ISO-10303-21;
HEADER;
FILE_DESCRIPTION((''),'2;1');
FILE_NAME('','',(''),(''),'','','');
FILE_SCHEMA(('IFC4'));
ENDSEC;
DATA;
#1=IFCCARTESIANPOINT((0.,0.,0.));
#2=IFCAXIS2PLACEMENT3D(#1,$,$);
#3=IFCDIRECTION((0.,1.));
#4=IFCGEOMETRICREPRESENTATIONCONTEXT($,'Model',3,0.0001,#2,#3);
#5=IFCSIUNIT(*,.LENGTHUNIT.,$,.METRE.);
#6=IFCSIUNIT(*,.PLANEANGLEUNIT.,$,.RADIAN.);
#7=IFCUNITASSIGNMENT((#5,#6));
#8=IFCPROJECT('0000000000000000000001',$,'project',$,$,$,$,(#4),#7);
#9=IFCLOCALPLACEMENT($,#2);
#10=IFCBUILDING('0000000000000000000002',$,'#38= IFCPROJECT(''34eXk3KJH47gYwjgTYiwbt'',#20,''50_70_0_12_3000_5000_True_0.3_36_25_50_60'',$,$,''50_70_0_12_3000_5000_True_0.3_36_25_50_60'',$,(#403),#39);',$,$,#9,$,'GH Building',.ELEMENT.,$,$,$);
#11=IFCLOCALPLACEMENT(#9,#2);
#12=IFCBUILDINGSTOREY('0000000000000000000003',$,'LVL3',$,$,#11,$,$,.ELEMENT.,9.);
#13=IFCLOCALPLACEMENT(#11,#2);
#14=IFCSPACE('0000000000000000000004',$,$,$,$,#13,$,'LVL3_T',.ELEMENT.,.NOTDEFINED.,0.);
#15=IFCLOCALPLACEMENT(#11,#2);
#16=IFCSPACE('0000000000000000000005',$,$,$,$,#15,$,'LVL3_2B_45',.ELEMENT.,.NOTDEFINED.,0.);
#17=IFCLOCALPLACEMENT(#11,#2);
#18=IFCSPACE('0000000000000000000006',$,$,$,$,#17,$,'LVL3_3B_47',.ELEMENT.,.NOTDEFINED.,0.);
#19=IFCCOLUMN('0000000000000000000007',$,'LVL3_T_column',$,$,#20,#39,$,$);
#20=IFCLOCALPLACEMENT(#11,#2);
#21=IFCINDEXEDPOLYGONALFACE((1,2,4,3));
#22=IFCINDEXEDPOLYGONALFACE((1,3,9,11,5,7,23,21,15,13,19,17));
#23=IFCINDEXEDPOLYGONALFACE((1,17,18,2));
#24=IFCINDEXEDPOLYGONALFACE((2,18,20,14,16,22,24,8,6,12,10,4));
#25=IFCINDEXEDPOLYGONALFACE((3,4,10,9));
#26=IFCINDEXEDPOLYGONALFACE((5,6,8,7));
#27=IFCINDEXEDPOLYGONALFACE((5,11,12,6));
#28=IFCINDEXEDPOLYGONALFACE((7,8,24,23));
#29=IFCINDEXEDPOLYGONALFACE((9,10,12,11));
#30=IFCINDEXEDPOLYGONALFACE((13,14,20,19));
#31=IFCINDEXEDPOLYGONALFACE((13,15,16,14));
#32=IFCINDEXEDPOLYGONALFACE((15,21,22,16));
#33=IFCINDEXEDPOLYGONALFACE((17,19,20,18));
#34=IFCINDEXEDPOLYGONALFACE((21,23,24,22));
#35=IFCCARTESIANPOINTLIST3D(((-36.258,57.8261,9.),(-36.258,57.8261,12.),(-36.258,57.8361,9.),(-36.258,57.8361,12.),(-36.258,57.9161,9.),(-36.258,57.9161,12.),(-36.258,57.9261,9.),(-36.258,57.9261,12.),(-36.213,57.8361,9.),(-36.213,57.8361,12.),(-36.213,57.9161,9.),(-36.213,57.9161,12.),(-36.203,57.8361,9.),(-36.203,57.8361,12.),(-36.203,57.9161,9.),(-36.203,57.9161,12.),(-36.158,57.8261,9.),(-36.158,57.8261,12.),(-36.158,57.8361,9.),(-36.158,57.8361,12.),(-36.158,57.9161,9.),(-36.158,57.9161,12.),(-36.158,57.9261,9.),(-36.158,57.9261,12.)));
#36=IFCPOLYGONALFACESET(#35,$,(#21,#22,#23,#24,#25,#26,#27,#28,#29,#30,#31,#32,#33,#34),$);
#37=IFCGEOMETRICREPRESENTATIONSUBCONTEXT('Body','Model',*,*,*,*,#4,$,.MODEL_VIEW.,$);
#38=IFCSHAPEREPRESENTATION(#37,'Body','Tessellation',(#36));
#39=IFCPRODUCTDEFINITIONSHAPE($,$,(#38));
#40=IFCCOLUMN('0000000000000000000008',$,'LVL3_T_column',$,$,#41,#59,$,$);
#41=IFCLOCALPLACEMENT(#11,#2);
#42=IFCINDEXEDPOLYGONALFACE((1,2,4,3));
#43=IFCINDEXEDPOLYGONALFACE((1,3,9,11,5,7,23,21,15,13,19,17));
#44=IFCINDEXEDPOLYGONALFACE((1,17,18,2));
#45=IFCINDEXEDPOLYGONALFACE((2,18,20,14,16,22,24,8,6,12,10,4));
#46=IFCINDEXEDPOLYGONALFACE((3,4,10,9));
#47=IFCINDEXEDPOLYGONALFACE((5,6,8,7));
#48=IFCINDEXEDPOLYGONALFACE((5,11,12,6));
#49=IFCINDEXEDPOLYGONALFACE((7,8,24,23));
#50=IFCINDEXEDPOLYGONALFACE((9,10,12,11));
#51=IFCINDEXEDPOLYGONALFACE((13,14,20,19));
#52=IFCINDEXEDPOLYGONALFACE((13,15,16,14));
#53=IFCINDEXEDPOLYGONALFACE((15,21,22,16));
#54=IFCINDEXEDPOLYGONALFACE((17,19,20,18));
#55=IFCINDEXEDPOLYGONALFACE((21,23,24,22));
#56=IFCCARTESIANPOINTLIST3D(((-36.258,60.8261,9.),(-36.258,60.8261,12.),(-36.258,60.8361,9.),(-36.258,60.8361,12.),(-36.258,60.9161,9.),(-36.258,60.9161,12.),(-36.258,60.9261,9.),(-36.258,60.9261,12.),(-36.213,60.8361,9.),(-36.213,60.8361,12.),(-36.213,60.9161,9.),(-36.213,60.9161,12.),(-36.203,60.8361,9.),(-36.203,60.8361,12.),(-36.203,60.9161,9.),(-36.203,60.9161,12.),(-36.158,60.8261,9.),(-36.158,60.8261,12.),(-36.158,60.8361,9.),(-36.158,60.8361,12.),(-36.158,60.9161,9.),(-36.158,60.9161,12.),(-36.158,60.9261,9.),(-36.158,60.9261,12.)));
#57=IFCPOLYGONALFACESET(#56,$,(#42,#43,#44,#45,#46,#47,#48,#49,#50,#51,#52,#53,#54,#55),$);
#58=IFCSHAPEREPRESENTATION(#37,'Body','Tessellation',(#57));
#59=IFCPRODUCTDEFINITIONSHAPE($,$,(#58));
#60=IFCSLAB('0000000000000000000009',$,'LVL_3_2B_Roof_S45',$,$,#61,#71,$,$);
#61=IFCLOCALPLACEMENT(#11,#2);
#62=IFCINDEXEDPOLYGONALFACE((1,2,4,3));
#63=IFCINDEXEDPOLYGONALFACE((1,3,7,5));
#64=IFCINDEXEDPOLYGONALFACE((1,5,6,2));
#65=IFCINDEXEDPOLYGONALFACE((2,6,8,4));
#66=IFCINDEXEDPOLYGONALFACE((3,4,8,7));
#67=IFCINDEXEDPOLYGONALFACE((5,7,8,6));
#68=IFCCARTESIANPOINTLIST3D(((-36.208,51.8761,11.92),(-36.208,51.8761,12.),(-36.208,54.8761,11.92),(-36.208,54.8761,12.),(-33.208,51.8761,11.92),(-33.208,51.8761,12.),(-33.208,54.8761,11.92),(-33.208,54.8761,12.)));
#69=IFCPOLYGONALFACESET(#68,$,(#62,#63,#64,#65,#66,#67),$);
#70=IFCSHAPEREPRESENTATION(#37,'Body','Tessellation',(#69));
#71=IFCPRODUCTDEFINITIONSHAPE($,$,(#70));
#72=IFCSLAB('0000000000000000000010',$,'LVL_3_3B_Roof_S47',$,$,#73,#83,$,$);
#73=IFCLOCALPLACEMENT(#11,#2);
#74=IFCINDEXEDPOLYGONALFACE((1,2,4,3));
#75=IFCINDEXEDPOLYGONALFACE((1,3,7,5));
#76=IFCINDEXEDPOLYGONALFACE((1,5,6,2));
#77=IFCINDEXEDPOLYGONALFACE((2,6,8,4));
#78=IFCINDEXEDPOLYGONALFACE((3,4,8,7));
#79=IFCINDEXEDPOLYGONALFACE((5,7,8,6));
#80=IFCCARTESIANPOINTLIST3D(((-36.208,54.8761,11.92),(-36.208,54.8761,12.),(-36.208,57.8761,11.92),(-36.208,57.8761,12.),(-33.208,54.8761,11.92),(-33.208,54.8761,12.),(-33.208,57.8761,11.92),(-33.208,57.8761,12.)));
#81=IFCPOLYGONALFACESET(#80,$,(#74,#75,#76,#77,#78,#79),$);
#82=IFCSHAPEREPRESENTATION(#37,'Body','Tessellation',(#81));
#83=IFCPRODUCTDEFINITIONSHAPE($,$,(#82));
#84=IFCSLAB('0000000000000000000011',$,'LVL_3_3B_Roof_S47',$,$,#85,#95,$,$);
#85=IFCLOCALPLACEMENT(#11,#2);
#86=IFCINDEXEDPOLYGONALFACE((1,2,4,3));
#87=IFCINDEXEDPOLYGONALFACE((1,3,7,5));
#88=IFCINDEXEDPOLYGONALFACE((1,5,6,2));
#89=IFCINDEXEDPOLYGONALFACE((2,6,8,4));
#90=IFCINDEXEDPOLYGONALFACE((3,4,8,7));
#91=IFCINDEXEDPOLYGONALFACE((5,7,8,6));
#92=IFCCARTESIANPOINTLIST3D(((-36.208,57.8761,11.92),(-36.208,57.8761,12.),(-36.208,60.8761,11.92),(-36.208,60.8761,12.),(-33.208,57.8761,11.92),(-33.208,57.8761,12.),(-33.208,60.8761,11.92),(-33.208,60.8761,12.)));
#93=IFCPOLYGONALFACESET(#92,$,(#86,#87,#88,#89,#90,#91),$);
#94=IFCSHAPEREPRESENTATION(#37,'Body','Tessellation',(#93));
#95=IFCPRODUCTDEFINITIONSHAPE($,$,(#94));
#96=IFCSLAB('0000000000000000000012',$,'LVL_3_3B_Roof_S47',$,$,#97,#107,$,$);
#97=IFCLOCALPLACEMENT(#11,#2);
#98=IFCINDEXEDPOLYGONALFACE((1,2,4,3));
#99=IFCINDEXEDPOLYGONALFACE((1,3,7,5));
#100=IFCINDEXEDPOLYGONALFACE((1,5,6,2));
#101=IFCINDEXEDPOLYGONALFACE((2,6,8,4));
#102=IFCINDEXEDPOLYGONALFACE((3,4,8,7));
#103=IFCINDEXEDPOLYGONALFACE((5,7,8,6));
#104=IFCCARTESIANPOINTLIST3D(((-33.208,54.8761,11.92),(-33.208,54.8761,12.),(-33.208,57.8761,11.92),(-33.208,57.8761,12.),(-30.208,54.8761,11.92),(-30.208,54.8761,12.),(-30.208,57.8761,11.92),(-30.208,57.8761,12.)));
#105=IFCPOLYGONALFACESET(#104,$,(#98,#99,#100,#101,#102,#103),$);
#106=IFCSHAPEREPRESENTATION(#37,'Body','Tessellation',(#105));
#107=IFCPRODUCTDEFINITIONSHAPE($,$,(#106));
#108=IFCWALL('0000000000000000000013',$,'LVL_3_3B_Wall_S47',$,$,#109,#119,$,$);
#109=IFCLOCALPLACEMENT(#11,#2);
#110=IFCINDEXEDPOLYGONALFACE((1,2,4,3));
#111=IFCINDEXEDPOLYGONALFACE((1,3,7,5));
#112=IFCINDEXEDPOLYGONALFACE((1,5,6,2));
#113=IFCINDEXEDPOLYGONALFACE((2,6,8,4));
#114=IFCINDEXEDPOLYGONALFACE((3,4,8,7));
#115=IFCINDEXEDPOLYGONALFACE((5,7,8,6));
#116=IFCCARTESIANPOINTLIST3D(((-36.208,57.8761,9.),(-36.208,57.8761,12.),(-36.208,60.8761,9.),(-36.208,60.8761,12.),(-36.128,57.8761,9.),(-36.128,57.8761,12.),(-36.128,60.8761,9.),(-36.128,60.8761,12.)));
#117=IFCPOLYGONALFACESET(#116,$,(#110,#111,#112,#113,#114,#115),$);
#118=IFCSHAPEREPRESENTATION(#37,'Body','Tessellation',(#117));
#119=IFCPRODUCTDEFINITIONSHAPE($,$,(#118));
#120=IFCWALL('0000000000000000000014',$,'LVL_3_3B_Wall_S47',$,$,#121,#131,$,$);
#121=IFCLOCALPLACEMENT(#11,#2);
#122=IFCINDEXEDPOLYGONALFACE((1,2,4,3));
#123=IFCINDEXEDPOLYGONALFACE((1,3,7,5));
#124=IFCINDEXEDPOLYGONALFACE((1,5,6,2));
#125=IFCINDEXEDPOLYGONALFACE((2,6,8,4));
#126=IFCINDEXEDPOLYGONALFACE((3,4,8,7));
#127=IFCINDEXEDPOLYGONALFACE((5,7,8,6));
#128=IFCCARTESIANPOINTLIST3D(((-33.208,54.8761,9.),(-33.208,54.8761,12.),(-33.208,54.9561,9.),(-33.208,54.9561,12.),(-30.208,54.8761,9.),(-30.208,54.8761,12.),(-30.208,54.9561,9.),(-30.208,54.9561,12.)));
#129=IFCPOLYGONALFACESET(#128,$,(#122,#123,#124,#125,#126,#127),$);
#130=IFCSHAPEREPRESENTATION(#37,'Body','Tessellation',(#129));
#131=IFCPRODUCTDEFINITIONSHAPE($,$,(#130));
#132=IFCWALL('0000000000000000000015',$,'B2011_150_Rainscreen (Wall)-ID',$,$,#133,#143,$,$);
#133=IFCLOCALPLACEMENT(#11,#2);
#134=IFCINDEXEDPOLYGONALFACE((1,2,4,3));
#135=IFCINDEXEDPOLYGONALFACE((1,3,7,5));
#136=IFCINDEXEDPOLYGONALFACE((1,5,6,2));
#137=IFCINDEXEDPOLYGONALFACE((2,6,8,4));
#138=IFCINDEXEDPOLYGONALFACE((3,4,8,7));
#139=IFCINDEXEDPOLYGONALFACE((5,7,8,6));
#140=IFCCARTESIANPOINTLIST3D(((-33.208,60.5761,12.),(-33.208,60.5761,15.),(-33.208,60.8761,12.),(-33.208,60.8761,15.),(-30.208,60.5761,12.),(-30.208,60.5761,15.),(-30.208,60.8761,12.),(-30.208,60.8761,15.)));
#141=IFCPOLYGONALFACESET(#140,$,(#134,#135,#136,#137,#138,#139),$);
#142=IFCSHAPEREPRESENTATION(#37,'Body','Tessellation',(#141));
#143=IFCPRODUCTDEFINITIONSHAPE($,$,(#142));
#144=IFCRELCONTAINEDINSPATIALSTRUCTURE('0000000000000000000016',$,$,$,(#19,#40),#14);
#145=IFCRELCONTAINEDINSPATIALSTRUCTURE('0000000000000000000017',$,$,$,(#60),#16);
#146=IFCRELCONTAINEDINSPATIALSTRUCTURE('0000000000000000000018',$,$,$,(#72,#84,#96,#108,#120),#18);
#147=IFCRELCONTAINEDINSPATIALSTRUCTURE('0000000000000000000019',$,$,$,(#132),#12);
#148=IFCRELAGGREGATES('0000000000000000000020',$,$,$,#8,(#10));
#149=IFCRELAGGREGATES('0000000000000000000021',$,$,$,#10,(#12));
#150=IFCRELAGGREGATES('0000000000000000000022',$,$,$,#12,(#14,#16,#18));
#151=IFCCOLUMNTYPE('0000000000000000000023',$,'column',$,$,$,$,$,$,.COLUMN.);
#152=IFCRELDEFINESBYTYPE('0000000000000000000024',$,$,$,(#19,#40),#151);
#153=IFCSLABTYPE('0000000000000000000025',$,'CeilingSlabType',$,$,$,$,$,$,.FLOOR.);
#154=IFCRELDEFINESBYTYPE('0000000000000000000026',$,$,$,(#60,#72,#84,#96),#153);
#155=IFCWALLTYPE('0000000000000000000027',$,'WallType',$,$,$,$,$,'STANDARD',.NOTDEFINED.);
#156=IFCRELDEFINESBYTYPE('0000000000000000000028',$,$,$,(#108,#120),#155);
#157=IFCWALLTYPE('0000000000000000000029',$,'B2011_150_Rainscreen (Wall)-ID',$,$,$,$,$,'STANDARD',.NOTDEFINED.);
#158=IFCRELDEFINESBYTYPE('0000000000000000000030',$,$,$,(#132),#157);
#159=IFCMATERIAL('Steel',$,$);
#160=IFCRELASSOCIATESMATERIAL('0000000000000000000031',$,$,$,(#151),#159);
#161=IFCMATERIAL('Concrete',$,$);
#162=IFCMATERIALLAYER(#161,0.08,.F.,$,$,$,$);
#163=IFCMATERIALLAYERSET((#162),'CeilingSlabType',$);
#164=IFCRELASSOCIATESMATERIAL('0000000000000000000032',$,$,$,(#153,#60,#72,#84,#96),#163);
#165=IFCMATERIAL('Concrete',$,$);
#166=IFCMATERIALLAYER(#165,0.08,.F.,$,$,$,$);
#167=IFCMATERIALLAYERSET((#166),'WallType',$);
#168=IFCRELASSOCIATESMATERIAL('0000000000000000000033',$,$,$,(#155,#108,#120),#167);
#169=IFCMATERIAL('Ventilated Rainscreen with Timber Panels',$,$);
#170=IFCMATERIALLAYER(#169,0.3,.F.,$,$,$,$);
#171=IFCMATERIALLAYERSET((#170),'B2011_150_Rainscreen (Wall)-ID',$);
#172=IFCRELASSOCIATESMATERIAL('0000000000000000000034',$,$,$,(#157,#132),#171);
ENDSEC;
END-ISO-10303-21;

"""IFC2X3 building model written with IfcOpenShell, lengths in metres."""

from ifc_helpers import new_model, si_unit, direction, frame, frame_2d, origin, origin_2d, place, context, subcontext, project, spatial, rectangle, i_section, extrude, material, layer, layer_set, layer_usage, type_object, element, save


model = new_model("IFC2X3")

# Units and contexts
model_context = context("Model", 3, precision=0.0001, world=origin(), true_north=direction((0.0, 1.0)))
body_context = subcontext(model_context, "Body", "Model", "MODEL_VIEW")
ifc_project = project(units=[si_unit("LENGTHUNIT", "METRE"), si_unit("PLANEANGLEUNIT", "RADIAN")], contexts=[model_context])

# Building, storey, space
building_placement = place(None, origin())
building = spatial("IfcBuilding", under=ifc_project, at=building_placement, Name="#38= IFCPROJECT('34eXk3KJH47gYwjgTYiwbt',#20,'50_70_0_12_3000_5000_True_0.3_36_25_50_60',$,$,'50_70_0_12_3000_5000_True_0.3_36_25_50_60',$,(#403),#39);", LongName="GH Building", CompositionType="ELEMENT")
storey_placement = place(building_placement, origin())
storey = spatial("IfcBuildingStorey", under=building, at=storey_placement, Name="LVL3", CompositionType="ELEMENT", Elevation=9.0)
space_1_placement = place(storey_placement, origin())
space_1 = spatial("IfcSpace", under=storey, at=space_1_placement, LongName="LVL3_T", CompositionType="ELEMENT", InteriorOrExteriorSpace="NOTDEFINED", ElevationWithFlooring=0.0)

# Columns
ifc_material_1 = material(Name="Steel")
column_type = type_object("IfcColumnType", Name="column", PredefinedType="COLUMN", material=ifc_material_1)
for number, where, name in (
    (1, (-36.208, 57.8761, 9.0), "LVL3_T_column"),
    (2, (-36.208, 60.8761, 9.0), "LVL3_T_column"),
):
    element("IfcColumn", number, at=place(space_1_placement, frame(where)), inside=space_1, type_object=column_type, Name=name, context=body_context, shape_type="SweptSolid", body=[
        extrude(i_section(OverallWidth=0.1, OverallDepth=0.1, WebThickness=0.01, FlangeThickness=0.01, at=origin_2d()), origin(), (0.0, 0.0, 1.0), 3.0),
    ])

# Shared definitions
space_2_placement = place(storey_placement, origin())
space_2 = spatial("IfcSpace", under=storey, at=space_2_placement, LongName="LVL3_2B_45", CompositionType="ELEMENT", InteriorOrExteriorSpace="NOTDEFINED", ElevationWithFlooring=0.0)

# Slab
ifc_material_2 = material(Name="Concrete")
ifc_layer_1 = layer(ifc_material_2, 0.08, ventilated=False)
ifc_layer_set_1 = layer_set([ifc_layer_1], Name="CeilingSlabType")
ifc_layer_usage_1 = layer_usage(ifc_layer_set_1, "AXIS3", "NEGATIVE", -0.08)
slab_type = type_object("IfcSlabType", Name="CeilingSlabType", PredefinedType="FLOOR", material=ifc_layer_set_1)
slab_1_placement = place(space_2_placement, frame((-33.208, 51.8761, 11.92), z_axis=(0.0, 0.0, 1.0), x_axis=(0.0, 1.0, 0.0)))
element("IfcSlab", 3, at=slab_1_placement, inside=space_2, type_object=slab_type, material=ifc_layer_usage_1, Name="LVL_3_2B_Roof_S45", context=body_context, shape_type="SweptSolid", body=[
    extrude(rectangle(XDim=3.0, YDim=3.0, at=frame_2d((1.5, 1.5))), origin(), (0.0, 0.0, 1.0), 0.08),
])

# Shared definitions
space_3_placement = place(storey_placement, origin())
space_3 = spatial("IfcSpace", under=storey, at=space_3_placement, LongName="LVL3_3B_47", CompositionType="ELEMENT", InteriorOrExteriorSpace="NOTDEFINED", ElevationWithFlooring=0.0)

# Slabs
ifc_layer_usage_2 = layer_usage(ifc_layer_set_1, "AXIS3", "NEGATIVE", -0.08)
slab_2_placement = place(space_3_placement, frame((-33.208, 54.8761, 11.92), z_axis=(0.0, 0.0, 1.0), x_axis=(0.0, 1.0, 0.0)))
element("IfcSlab", 4, at=slab_2_placement, inside=space_3, type_object=slab_type, material=ifc_layer_usage_2, Name="LVL_3_3B_Roof_S47", context=body_context, shape_type="SweptSolid", body=[
    extrude(rectangle(XDim=3.0, YDim=3.0, at=frame_2d((1.5, 1.5))), origin(), (0.0, 0.0, 1.0), 0.08),
])
ifc_layer_usage_3 = layer_usage(ifc_layer_set_1, "AXIS3", "NEGATIVE", -0.08)
slab_3_placement = place(space_3_placement, frame((-33.208, 57.8761, 11.92), z_axis=(0.0, 0.0, 1.0), x_axis=(0.0, 1.0, 0.0)))
element("IfcSlab", 5, at=slab_3_placement, inside=space_3, type_object=slab_type, material=ifc_layer_usage_3, Name="LVL_3_3B_Roof_S47", context=body_context, shape_type="SweptSolid", body=[
    extrude(rectangle(XDim=3.0, YDim=3.0, at=frame_2d((1.5, 1.5))), origin(), (0.0, 0.0, 1.0), 0.08),
])
ifc_layer_usage_4 = layer_usage(ifc_layer_set_1, "AXIS3", "NEGATIVE", -0.08)
slab_4_placement = place(space_3_placement, frame((-30.208, 54.8761, 11.92), z_axis=(0.0, 0.0, 1.0), x_axis=(0.0, 1.0, 0.0)))
element("IfcSlab", 6, at=slab_4_placement, inside=space_3, type_object=slab_type, material=ifc_layer_usage_4, Name="LVL_3_3B_Roof_S47", context=body_context, shape_type="SweptSolid", body=[
    extrude(rectangle(XDim=3.0, YDim=3.0, at=frame_2d((1.5, 1.5))), origin(), (0.0, 0.0, 1.0), 0.08),
])

# Shared definitions
ifc_material_3 = material(Name="Concrete")
ifc_layer_2 = layer(ifc_material_3, 0.08, ventilated=False)
ifc_layer_set_2 = layer_set([ifc_layer_2], Name="WallType")
wall_type_1 = type_object("IfcWallType", Name="WallType", ElementType="STANDARD", PredefinedType="NOTDEFINED", material=ifc_layer_set_2)

# Walls
ifc_layer_usage_5 = layer_usage(ifc_layer_set_2, "AXIS2", "NEGATIVE", 0.0)
wall_1_placement = place(space_3_placement, frame((-36.208, 57.8761, 9.0), z_axis=(0.0, 0.0, 1.0), x_axis=(0.0, 1.0, 0.0)))
element("IfcWall", 7, at=wall_1_placement, inside=space_3, type_object=wall_type_1, material=ifc_layer_usage_5, Name="LVL_3_3B_Wall_S47", context=body_context, shape_type="SweptSolid", body=[
    extrude(rectangle(XDim=3.0, YDim=0.08, at=frame_2d((1.5, -0.04))), origin(), (0.0, 0.0, 1.0), 3.0),
])
ifc_layer_usage_6 = layer_usage(ifc_layer_set_2, "AXIS2", "NEGATIVE", 0.0)
wall_2_placement = place(space_3_placement, frame((-30.208, 54.8761, 9.0), z_axis=(0.0, 0.0, 1.0), x_axis=(-1.0, 0.0, 0.0)))
element("IfcWall", 8, at=wall_2_placement, inside=space_3, type_object=wall_type_1, material=ifc_layer_usage_6, Name="LVL_3_3B_Wall_S47", context=body_context, shape_type="SweptSolid", body=[
    extrude(rectangle(XDim=3.0, YDim=0.08, at=frame_2d((1.5, -0.04))), origin(), (0.0, 0.0, 1.0), 3.0),
])
ifc_material_4 = material(Name="Ventilated Rainscreen with Timber Panels")
ifc_layer_3 = layer(ifc_material_4, 0.3, ventilated=False)
ifc_layer_set_3 = layer_set([ifc_layer_3], Name="B2011_150_Rainscreen (Wall)-ID")
ifc_layer_usage_7 = layer_usage(ifc_layer_set_3, "AXIS2", "POSITIVE", 0.0)
wall_type_2 = type_object("IfcWallType", Name="B2011_150_Rainscreen (Wall)-ID", ElementType="STANDARD", PredefinedType="NOTDEFINED", material=ifc_layer_set_3)
wall_3_placement = place(storey_placement, frame((-30.208, 60.8761, 12.0), z_axis=(0.0, 0.0, 1.0), x_axis=(-1.0, 0.0, 0.0)))
element("IfcWall", 9, at=wall_3_placement, inside=storey, type_object=wall_type_2, material=ifc_layer_usage_7, Name="B2011_150_Rainscreen (Wall)-ID", context=body_context, shape_type="SweptSolid", body=[
    extrude(rectangle(XDim=3.0, YDim=0.3, at=frame_2d((1.5, 0.15))), origin(), (0.0, 0.0, 1.0), 3.0),
])

save(model, "model.ifc")
